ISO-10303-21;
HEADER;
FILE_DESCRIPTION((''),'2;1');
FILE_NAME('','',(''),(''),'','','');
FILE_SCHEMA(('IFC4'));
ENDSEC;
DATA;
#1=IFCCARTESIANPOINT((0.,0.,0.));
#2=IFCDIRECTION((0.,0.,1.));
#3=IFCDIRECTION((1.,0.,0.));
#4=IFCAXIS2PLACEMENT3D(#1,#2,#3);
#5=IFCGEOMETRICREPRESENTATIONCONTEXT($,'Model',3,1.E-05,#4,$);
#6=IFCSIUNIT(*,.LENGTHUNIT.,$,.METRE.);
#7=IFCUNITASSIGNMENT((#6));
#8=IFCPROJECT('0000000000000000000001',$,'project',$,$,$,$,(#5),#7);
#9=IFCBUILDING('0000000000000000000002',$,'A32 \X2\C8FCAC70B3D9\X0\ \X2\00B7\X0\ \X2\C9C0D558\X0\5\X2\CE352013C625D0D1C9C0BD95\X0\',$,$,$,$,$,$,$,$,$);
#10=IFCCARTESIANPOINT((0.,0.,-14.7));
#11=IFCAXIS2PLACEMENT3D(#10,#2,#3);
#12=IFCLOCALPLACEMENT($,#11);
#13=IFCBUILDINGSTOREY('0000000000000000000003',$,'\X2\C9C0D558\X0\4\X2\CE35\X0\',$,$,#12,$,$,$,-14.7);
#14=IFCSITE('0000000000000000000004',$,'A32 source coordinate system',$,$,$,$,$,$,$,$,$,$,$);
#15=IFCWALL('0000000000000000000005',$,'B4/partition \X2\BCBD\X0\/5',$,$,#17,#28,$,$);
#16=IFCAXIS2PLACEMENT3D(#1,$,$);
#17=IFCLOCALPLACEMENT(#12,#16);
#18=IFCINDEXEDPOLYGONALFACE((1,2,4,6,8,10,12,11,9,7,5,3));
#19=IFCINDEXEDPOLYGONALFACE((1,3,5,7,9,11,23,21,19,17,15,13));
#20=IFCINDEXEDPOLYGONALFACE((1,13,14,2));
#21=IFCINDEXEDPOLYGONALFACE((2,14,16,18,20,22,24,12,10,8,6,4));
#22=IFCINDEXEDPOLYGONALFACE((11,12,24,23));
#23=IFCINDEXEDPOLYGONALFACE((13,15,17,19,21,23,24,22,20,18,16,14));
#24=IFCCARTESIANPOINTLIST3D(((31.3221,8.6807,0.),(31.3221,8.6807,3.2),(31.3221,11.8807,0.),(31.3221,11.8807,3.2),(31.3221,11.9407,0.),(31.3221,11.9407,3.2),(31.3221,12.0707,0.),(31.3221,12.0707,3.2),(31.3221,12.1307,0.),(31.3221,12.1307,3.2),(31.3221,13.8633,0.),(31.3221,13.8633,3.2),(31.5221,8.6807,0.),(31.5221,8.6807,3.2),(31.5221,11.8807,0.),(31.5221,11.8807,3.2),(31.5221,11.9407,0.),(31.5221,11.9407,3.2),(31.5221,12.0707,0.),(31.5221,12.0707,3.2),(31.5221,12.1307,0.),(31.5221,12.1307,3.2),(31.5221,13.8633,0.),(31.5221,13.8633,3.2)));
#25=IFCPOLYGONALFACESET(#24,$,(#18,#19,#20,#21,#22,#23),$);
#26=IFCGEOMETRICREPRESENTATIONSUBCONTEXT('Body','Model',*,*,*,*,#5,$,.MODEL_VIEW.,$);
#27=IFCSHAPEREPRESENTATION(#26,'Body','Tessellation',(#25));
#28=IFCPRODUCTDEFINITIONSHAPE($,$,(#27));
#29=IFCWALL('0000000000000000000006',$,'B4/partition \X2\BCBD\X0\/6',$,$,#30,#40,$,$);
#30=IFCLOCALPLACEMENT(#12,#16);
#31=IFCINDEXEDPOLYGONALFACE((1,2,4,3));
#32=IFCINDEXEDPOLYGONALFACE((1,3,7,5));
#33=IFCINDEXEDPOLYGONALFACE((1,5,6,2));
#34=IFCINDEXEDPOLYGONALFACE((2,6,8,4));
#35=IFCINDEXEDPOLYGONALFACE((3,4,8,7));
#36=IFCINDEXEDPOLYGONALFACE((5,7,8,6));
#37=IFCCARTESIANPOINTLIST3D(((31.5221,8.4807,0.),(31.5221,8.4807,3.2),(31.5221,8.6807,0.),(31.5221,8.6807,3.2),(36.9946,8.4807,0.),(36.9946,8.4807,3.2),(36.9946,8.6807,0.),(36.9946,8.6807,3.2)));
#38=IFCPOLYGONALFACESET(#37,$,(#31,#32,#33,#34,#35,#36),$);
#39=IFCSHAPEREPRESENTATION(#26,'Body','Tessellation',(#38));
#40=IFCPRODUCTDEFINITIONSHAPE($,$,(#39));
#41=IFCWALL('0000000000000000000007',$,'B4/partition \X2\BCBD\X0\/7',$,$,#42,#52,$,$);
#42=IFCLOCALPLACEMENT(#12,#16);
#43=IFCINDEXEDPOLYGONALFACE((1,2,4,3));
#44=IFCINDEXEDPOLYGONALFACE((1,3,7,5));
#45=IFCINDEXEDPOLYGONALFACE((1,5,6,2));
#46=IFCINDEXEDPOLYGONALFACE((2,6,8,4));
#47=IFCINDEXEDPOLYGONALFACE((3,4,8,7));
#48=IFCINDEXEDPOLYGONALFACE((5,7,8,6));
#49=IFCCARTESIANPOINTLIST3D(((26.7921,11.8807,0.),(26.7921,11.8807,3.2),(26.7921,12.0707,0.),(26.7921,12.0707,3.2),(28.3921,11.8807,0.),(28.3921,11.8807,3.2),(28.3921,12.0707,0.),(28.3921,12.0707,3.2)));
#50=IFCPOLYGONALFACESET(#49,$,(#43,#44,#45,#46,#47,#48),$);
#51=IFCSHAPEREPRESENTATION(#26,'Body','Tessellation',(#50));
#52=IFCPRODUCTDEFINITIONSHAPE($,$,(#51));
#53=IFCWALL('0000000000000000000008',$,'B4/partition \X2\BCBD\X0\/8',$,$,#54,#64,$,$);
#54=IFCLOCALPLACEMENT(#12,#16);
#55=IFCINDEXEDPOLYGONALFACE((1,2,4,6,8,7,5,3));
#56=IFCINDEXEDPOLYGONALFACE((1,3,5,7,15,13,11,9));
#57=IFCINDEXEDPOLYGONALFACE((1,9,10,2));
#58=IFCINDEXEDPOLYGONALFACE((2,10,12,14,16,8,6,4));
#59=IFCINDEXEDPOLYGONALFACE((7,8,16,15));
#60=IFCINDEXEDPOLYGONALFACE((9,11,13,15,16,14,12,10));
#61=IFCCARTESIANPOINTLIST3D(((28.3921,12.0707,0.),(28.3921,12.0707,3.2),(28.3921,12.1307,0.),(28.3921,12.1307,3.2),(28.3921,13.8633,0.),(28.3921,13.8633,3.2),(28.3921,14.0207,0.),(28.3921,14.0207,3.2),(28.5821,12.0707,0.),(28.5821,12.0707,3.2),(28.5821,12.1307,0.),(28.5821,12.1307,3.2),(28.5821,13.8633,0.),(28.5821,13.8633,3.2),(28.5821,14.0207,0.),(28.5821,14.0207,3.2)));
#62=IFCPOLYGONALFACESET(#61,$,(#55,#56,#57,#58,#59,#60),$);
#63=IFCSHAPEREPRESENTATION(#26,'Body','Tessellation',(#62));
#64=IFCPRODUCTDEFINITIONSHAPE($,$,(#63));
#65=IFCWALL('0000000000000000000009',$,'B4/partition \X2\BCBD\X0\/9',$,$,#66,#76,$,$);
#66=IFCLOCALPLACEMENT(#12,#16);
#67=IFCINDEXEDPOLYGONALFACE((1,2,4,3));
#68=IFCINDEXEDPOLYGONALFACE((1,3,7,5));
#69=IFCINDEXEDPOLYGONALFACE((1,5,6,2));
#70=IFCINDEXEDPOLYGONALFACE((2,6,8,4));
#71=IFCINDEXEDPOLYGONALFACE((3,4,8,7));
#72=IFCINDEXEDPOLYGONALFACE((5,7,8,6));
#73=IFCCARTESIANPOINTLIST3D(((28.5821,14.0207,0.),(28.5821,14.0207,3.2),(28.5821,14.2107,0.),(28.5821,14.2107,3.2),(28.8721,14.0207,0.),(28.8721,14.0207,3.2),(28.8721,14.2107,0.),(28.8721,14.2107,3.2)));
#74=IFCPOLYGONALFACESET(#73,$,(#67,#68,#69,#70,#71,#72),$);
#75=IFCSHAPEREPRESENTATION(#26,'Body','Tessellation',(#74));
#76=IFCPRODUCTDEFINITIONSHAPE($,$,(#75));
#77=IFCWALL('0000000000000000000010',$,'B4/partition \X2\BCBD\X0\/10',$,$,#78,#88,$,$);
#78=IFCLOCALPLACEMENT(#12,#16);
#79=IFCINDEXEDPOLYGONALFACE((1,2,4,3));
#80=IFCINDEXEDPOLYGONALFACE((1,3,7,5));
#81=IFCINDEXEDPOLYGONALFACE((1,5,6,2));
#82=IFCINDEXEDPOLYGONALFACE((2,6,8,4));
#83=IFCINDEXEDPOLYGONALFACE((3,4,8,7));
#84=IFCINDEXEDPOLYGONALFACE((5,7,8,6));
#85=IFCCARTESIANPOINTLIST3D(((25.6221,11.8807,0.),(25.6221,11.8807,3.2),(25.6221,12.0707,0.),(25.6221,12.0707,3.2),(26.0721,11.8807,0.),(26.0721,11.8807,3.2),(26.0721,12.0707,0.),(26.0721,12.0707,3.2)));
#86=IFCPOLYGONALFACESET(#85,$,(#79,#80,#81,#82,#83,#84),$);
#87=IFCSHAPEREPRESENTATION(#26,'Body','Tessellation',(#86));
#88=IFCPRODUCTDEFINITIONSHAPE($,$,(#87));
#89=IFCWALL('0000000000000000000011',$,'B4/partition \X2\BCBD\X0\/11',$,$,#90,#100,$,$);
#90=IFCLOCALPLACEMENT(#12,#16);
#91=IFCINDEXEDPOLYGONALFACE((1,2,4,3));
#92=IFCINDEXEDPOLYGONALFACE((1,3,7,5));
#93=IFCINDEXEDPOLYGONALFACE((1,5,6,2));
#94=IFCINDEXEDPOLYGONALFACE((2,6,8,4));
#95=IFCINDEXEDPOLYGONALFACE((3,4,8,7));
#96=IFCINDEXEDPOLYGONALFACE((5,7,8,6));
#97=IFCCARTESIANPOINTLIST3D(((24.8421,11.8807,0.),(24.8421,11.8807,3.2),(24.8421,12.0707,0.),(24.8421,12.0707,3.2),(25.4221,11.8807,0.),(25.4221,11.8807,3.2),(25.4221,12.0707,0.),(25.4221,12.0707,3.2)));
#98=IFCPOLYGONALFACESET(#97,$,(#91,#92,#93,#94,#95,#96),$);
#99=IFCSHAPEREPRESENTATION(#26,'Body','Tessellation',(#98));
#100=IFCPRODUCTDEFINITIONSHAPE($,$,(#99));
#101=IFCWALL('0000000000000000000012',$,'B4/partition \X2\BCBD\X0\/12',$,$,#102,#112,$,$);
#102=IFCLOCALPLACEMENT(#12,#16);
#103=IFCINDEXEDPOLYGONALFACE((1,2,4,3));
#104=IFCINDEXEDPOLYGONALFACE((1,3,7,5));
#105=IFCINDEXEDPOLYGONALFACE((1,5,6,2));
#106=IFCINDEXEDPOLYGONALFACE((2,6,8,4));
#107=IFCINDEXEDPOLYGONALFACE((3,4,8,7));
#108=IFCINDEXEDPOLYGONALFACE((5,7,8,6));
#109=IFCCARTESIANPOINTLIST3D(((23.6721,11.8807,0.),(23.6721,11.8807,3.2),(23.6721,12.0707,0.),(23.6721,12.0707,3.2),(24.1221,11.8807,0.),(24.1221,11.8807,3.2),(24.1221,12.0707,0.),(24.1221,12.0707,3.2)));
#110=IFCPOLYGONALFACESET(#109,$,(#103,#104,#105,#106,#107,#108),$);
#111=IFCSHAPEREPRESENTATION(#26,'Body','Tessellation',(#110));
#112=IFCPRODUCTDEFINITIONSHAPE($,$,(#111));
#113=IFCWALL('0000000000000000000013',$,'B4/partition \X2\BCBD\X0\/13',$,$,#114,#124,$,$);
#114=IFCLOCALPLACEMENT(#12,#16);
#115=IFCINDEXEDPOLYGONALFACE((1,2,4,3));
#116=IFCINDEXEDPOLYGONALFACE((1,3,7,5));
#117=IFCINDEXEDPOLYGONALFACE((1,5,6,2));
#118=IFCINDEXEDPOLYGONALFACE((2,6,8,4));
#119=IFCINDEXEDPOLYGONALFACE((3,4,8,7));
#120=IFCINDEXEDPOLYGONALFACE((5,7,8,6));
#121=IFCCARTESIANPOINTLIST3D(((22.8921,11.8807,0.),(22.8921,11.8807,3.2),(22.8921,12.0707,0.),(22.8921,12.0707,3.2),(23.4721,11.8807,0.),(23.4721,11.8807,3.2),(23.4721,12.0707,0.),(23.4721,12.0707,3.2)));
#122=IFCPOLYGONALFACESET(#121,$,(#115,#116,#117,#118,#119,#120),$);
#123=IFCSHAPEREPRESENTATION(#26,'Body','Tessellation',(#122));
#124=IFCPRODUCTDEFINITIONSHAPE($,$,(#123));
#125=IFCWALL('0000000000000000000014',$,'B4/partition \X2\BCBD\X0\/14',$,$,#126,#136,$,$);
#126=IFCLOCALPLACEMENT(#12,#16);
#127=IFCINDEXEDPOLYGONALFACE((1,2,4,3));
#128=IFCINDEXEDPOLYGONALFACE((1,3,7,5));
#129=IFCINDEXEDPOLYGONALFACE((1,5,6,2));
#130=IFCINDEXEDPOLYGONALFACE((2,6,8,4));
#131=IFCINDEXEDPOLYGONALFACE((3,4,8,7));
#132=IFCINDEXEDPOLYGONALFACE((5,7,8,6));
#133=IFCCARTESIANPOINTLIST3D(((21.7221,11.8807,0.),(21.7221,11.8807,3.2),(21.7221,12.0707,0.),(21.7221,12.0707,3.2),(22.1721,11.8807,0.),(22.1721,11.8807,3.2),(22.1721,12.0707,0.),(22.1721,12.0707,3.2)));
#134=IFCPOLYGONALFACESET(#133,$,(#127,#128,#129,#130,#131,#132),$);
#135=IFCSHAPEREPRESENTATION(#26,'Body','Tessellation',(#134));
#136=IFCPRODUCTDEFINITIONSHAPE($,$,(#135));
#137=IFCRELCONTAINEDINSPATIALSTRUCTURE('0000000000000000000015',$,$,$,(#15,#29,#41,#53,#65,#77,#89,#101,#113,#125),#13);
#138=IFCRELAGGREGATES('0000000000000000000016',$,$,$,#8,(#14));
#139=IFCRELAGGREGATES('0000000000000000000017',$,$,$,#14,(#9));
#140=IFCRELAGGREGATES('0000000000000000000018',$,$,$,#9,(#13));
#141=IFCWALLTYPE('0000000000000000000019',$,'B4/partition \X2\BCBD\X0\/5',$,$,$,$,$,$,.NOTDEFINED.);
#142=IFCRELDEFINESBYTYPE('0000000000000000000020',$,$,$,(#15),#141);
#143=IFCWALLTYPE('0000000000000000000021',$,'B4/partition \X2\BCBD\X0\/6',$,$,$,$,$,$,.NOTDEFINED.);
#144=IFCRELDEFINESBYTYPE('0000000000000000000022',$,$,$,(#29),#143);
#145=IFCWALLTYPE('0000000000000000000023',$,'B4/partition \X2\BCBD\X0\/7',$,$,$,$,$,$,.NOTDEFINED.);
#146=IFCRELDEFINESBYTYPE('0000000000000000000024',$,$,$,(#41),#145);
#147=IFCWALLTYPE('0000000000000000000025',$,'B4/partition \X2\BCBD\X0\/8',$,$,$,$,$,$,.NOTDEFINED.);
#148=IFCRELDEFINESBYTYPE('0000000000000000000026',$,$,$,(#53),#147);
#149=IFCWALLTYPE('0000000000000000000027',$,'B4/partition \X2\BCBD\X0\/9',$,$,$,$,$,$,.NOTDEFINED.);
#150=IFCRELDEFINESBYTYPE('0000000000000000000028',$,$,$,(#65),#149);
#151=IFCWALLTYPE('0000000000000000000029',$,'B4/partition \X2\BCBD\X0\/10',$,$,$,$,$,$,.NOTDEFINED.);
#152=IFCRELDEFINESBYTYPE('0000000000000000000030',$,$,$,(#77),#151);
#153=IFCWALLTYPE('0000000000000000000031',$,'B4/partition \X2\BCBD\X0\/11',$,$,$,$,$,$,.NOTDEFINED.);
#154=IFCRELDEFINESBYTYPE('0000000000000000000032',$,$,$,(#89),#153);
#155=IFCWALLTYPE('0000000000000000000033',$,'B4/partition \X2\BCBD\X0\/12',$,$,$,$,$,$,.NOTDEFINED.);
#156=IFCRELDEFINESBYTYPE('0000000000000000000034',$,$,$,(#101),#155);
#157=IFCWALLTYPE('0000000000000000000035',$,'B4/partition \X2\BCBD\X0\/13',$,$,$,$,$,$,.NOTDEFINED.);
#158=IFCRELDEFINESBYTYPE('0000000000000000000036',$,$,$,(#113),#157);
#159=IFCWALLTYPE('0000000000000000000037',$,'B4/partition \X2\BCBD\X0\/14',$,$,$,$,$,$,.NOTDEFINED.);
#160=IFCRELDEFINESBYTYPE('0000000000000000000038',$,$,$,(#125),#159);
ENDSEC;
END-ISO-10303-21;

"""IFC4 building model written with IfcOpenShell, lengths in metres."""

from ifc_helpers import new_model, si_unit, frame, origin, origin_with_axes, place, context, subcontext, project, spatial, polyline, outline, extrude, source, transform, mapped, type_object, type_shapes, element, save


model = new_model("IFC4")

# Units and contexts
model_context = context("Model", 3, precision=1e-05, world=origin_with_axes())
body_context = subcontext(model_context, "Body", "Model", "MODEL_VIEW")
ifc_project = project(units=[si_unit("LENGTHUNIT", "METRE")], contexts=[model_context])

# Site, building, storey
site = spatial("IfcSite", under=ifc_project, Name="A32 source coordinate system")
building = spatial("IfcBuilding", under=site, Name="A32 주거동 · 지하5층–옥탑지붕")
storey_placement = place(None, frame((0.0, 0.0, -14.7), z_axis=(0.0, 0.0, 1.0), x_axis=(1.0, 0.0, 0.0)))
storey = spatial("IfcBuildingStorey", under=building, at=storey_placement, Name="지하4층", Elevation=-14.7)

# Walls
wall_type_1 = type_object("IfcWallType", Name="B4/partition 벽/5", PredefinedType="NOTDEFINED")
shared_shape_1 = source(origin(), body_context, "Body", "SweptSolid", [
    extrude(outline(polyline([(31.3221, 12.0707), (31.3221, 12.1307), (31.3221, 13.8633), (31.5221, 13.8633), (31.5221, 12.1307), (31.5221, 12.0707), (31.5221, 11.9407), (31.5221, 11.8807), (31.5221, 8.6807), (31.3221, 8.6807), (31.3221, 11.8807), (31.3221, 11.9407), (31.3221, 12.0707)])), origin(), (0.0, 0.0, 1.0), 3.2),
])
type_shapes(wall_type_1, [shared_shape_1])
wall_1_placement = place(storey_placement, origin_with_axes())
element("IfcWall", 1, at=wall_1_placement, inside=storey, type_object=wall_type_1, Name="B4/partition 벽/5", context=body_context, shape_type="MappedRepresentation", body=[
    mapped(shared_shape_1, transform((0.0, 0.0, 0.0), scale=1.0)),
])
wall_type_2 = type_object("IfcWallType", Name="B4/partition 벽/6", PredefinedType="NOTDEFINED")
shared_shape_2 = source(origin(), body_context, "Body", "SweptSolid", [
    extrude(outline(polyline([(36.9946, 8.6807), (36.9946, 8.4807), (31.5221, 8.4807), (31.5221, 8.6807), (36.9946, 8.6807)])), origin(), (0.0, 0.0, 1.0), 3.2),
])
type_shapes(wall_type_2, [shared_shape_2])
wall_2_placement = place(storey_placement, origin_with_axes())
element("IfcWall", 2, at=wall_2_placement, inside=storey, type_object=wall_type_2, Name="B4/partition 벽/6", context=body_context, shape_type="MappedRepresentation", body=[
    mapped(shared_shape_2, transform((0.0, 0.0, 0.0), scale=1.0)),
])
wall_type_3 = type_object("IfcWallType", Name="B4/partition 벽/7", PredefinedType="NOTDEFINED")
shared_shape_3 = source(origin(), body_context, "Body", "SweptSolid", [
    extrude(outline(polyline([(28.3921, 12.0707), (28.3921, 11.8807), (26.7921, 11.8807), (26.7921, 12.0707), (28.3921, 12.0707)])), origin(), (0.0, 0.0, 1.0), 3.2),
])
type_shapes(wall_type_3, [shared_shape_3])
wall_3_placement = place(storey_placement, origin_with_axes())
element("IfcWall", 3, at=wall_3_placement, inside=storey, type_object=wall_type_3, Name="B4/partition 벽/7", context=body_context, shape_type="MappedRepresentation", body=[
    mapped(shared_shape_3, transform((0.0, 0.0, 0.0), scale=1.0)),
])
wall_type_4 = type_object("IfcWallType", Name="B4/partition 벽/8", PredefinedType="NOTDEFINED")
shared_shape_4 = source(origin(), body_context, "Body", "SweptSolid", [
    extrude(outline(polyline([(28.3921, 12.1307), (28.3921, 13.8633), (28.3921, 14.0207), (28.5821, 14.0207), (28.5821, 13.8633), (28.5821, 12.1307), (28.5821, 12.0707), (28.3921, 12.0707), (28.3921, 12.1307)])), origin(), (0.0, 0.0, 1.0), 3.2),
])
type_shapes(wall_type_4, [shared_shape_4])
wall_4_placement = place(storey_placement, origin_with_axes())
element("IfcWall", 4, at=wall_4_placement, inside=storey, type_object=wall_type_4, Name="B4/partition 벽/8", context=body_context, shape_type="MappedRepresentation", body=[
    mapped(shared_shape_4, transform((0.0, 0.0, 0.0), scale=1.0)),
])
wall_type_5 = type_object("IfcWallType", Name="B4/partition 벽/9", PredefinedType="NOTDEFINED")
shared_shape_5 = source(origin(), body_context, "Body", "SweptSolid", [
    extrude(outline(polyline([(28.5821, 14.2107), (28.8721, 14.2107), (28.8721, 14.0207), (28.5821, 14.0207), (28.5821, 14.2107)])), origin(), (0.0, 0.0, 1.0), 3.2),
])
type_shapes(wall_type_5, [shared_shape_5])
wall_5_placement = place(storey_placement, origin_with_axes())
element("IfcWall", 5, at=wall_5_placement, inside=storey, type_object=wall_type_5, Name="B4/partition 벽/9", context=body_context, shape_type="MappedRepresentation", body=[
    mapped(shared_shape_5, transform((0.0, 0.0, 0.0), scale=1.0)),
])
wall_type_6 = type_object("IfcWallType", Name="B4/partition 벽/10", PredefinedType="NOTDEFINED")
shared_shape_6 = source(origin(), body_context, "Body", "SweptSolid", [
    extrude(outline(polyline([(26.0721, 12.0707), (26.0721, 11.8807), (25.6221, 11.8807), (25.6221, 12.0707), (26.0721, 12.0707)])), origin(), (0.0, 0.0, 1.0), 3.2),
])
type_shapes(wall_type_6, [shared_shape_6])
wall_6_placement = place(storey_placement, origin_with_axes())
element("IfcWall", 6, at=wall_6_placement, inside=storey, type_object=wall_type_6, Name="B4/partition 벽/10", context=body_context, shape_type="MappedRepresentation", body=[
    mapped(shared_shape_6, transform((0.0, 0.0, 0.0), scale=1.0)),
])
wall_type_7 = type_object("IfcWallType", Name="B4/partition 벽/11", PredefinedType="NOTDEFINED")
shared_shape_7 = source(origin(), body_context, "Body", "SweptSolid", [
    extrude(outline(polyline([(24.8421, 12.0707), (25.4221, 12.0707), (25.4221, 11.8807), (24.8421, 11.8807), (24.8421, 12.0707)])), origin(), (0.0, 0.0, 1.0), 3.2),
])
type_shapes(wall_type_7, [shared_shape_7])
wall_7_placement = place(storey_placement, origin_with_axes())
element("IfcWall", 7, at=wall_7_placement, inside=storey, type_object=wall_type_7, Name="B4/partition 벽/11", context=body_context, shape_type="MappedRepresentation", body=[
    mapped(shared_shape_7, transform((0.0, 0.0, 0.0), scale=1.0)),
])
wall_type_8 = type_object("IfcWallType", Name="B4/partition 벽/12", PredefinedType="NOTDEFINED")
shared_shape_8 = source(origin(), body_context, "Body", "SweptSolid", [
    extrude(outline(polyline([(24.1221, 12.0707), (24.1221, 11.8807), (23.6721, 11.8807), (23.6721, 12.0707), (24.1221, 12.0707)])), origin(), (0.0, 0.0, 1.0), 3.2),
])
type_shapes(wall_type_8, [shared_shape_8])
wall_8_placement = place(storey_placement, origin_with_axes())
element("IfcWall", 8, at=wall_8_placement, inside=storey, type_object=wall_type_8, Name="B4/partition 벽/12", context=body_context, shape_type="MappedRepresentation", body=[
    mapped(shared_shape_8, transform((0.0, 0.0, 0.0), scale=1.0)),
])
wall_type_9 = type_object("IfcWallType", Name="B4/partition 벽/13", PredefinedType="NOTDEFINED")
shared_shape_9 = source(origin(), body_context, "Body", "SweptSolid", [
    extrude(outline(polyline([(23.4721, 12.0707), (23.4721, 11.8807), (22.8921, 11.8807), (22.8921, 12.0707), (23.4721, 12.0707)])), origin(), (0.0, 0.0, 1.0), 3.2),
])
type_shapes(wall_type_9, [shared_shape_9])
wall_9_placement = place(storey_placement, origin_with_axes())
element("IfcWall", 9, at=wall_9_placement, inside=storey, type_object=wall_type_9, Name="B4/partition 벽/13", context=body_context, shape_type="MappedRepresentation", body=[
    mapped(shared_shape_9, transform((0.0, 0.0, 0.0), scale=1.0)),
])
wall_type_10 = type_object("IfcWallType", Name="B4/partition 벽/14", PredefinedType="NOTDEFINED")
shared_shape_10 = source(origin(), body_context, "Body", "SweptSolid", [
    extrude(outline(polyline([(22.1721, 12.0707), (22.1721, 11.8807), (21.7221, 11.8807), (21.7221, 12.0707), (22.1721, 12.0707)])), origin(), (0.0, 0.0, 1.0), 3.2),
])
type_shapes(wall_type_10, [shared_shape_10])
wall_10_placement = place(storey_placement, origin_with_axes())
element("IfcWall", 10, at=wall_10_placement, inside=storey, type_object=wall_type_10, Name="B4/partition 벽/14", context=body_context, shape_type="MappedRepresentation", body=[
    mapped(shared_shape_10, transform((0.0, 0.0, 0.0), scale=1.0)),
])

save(model, "model.ifc")
